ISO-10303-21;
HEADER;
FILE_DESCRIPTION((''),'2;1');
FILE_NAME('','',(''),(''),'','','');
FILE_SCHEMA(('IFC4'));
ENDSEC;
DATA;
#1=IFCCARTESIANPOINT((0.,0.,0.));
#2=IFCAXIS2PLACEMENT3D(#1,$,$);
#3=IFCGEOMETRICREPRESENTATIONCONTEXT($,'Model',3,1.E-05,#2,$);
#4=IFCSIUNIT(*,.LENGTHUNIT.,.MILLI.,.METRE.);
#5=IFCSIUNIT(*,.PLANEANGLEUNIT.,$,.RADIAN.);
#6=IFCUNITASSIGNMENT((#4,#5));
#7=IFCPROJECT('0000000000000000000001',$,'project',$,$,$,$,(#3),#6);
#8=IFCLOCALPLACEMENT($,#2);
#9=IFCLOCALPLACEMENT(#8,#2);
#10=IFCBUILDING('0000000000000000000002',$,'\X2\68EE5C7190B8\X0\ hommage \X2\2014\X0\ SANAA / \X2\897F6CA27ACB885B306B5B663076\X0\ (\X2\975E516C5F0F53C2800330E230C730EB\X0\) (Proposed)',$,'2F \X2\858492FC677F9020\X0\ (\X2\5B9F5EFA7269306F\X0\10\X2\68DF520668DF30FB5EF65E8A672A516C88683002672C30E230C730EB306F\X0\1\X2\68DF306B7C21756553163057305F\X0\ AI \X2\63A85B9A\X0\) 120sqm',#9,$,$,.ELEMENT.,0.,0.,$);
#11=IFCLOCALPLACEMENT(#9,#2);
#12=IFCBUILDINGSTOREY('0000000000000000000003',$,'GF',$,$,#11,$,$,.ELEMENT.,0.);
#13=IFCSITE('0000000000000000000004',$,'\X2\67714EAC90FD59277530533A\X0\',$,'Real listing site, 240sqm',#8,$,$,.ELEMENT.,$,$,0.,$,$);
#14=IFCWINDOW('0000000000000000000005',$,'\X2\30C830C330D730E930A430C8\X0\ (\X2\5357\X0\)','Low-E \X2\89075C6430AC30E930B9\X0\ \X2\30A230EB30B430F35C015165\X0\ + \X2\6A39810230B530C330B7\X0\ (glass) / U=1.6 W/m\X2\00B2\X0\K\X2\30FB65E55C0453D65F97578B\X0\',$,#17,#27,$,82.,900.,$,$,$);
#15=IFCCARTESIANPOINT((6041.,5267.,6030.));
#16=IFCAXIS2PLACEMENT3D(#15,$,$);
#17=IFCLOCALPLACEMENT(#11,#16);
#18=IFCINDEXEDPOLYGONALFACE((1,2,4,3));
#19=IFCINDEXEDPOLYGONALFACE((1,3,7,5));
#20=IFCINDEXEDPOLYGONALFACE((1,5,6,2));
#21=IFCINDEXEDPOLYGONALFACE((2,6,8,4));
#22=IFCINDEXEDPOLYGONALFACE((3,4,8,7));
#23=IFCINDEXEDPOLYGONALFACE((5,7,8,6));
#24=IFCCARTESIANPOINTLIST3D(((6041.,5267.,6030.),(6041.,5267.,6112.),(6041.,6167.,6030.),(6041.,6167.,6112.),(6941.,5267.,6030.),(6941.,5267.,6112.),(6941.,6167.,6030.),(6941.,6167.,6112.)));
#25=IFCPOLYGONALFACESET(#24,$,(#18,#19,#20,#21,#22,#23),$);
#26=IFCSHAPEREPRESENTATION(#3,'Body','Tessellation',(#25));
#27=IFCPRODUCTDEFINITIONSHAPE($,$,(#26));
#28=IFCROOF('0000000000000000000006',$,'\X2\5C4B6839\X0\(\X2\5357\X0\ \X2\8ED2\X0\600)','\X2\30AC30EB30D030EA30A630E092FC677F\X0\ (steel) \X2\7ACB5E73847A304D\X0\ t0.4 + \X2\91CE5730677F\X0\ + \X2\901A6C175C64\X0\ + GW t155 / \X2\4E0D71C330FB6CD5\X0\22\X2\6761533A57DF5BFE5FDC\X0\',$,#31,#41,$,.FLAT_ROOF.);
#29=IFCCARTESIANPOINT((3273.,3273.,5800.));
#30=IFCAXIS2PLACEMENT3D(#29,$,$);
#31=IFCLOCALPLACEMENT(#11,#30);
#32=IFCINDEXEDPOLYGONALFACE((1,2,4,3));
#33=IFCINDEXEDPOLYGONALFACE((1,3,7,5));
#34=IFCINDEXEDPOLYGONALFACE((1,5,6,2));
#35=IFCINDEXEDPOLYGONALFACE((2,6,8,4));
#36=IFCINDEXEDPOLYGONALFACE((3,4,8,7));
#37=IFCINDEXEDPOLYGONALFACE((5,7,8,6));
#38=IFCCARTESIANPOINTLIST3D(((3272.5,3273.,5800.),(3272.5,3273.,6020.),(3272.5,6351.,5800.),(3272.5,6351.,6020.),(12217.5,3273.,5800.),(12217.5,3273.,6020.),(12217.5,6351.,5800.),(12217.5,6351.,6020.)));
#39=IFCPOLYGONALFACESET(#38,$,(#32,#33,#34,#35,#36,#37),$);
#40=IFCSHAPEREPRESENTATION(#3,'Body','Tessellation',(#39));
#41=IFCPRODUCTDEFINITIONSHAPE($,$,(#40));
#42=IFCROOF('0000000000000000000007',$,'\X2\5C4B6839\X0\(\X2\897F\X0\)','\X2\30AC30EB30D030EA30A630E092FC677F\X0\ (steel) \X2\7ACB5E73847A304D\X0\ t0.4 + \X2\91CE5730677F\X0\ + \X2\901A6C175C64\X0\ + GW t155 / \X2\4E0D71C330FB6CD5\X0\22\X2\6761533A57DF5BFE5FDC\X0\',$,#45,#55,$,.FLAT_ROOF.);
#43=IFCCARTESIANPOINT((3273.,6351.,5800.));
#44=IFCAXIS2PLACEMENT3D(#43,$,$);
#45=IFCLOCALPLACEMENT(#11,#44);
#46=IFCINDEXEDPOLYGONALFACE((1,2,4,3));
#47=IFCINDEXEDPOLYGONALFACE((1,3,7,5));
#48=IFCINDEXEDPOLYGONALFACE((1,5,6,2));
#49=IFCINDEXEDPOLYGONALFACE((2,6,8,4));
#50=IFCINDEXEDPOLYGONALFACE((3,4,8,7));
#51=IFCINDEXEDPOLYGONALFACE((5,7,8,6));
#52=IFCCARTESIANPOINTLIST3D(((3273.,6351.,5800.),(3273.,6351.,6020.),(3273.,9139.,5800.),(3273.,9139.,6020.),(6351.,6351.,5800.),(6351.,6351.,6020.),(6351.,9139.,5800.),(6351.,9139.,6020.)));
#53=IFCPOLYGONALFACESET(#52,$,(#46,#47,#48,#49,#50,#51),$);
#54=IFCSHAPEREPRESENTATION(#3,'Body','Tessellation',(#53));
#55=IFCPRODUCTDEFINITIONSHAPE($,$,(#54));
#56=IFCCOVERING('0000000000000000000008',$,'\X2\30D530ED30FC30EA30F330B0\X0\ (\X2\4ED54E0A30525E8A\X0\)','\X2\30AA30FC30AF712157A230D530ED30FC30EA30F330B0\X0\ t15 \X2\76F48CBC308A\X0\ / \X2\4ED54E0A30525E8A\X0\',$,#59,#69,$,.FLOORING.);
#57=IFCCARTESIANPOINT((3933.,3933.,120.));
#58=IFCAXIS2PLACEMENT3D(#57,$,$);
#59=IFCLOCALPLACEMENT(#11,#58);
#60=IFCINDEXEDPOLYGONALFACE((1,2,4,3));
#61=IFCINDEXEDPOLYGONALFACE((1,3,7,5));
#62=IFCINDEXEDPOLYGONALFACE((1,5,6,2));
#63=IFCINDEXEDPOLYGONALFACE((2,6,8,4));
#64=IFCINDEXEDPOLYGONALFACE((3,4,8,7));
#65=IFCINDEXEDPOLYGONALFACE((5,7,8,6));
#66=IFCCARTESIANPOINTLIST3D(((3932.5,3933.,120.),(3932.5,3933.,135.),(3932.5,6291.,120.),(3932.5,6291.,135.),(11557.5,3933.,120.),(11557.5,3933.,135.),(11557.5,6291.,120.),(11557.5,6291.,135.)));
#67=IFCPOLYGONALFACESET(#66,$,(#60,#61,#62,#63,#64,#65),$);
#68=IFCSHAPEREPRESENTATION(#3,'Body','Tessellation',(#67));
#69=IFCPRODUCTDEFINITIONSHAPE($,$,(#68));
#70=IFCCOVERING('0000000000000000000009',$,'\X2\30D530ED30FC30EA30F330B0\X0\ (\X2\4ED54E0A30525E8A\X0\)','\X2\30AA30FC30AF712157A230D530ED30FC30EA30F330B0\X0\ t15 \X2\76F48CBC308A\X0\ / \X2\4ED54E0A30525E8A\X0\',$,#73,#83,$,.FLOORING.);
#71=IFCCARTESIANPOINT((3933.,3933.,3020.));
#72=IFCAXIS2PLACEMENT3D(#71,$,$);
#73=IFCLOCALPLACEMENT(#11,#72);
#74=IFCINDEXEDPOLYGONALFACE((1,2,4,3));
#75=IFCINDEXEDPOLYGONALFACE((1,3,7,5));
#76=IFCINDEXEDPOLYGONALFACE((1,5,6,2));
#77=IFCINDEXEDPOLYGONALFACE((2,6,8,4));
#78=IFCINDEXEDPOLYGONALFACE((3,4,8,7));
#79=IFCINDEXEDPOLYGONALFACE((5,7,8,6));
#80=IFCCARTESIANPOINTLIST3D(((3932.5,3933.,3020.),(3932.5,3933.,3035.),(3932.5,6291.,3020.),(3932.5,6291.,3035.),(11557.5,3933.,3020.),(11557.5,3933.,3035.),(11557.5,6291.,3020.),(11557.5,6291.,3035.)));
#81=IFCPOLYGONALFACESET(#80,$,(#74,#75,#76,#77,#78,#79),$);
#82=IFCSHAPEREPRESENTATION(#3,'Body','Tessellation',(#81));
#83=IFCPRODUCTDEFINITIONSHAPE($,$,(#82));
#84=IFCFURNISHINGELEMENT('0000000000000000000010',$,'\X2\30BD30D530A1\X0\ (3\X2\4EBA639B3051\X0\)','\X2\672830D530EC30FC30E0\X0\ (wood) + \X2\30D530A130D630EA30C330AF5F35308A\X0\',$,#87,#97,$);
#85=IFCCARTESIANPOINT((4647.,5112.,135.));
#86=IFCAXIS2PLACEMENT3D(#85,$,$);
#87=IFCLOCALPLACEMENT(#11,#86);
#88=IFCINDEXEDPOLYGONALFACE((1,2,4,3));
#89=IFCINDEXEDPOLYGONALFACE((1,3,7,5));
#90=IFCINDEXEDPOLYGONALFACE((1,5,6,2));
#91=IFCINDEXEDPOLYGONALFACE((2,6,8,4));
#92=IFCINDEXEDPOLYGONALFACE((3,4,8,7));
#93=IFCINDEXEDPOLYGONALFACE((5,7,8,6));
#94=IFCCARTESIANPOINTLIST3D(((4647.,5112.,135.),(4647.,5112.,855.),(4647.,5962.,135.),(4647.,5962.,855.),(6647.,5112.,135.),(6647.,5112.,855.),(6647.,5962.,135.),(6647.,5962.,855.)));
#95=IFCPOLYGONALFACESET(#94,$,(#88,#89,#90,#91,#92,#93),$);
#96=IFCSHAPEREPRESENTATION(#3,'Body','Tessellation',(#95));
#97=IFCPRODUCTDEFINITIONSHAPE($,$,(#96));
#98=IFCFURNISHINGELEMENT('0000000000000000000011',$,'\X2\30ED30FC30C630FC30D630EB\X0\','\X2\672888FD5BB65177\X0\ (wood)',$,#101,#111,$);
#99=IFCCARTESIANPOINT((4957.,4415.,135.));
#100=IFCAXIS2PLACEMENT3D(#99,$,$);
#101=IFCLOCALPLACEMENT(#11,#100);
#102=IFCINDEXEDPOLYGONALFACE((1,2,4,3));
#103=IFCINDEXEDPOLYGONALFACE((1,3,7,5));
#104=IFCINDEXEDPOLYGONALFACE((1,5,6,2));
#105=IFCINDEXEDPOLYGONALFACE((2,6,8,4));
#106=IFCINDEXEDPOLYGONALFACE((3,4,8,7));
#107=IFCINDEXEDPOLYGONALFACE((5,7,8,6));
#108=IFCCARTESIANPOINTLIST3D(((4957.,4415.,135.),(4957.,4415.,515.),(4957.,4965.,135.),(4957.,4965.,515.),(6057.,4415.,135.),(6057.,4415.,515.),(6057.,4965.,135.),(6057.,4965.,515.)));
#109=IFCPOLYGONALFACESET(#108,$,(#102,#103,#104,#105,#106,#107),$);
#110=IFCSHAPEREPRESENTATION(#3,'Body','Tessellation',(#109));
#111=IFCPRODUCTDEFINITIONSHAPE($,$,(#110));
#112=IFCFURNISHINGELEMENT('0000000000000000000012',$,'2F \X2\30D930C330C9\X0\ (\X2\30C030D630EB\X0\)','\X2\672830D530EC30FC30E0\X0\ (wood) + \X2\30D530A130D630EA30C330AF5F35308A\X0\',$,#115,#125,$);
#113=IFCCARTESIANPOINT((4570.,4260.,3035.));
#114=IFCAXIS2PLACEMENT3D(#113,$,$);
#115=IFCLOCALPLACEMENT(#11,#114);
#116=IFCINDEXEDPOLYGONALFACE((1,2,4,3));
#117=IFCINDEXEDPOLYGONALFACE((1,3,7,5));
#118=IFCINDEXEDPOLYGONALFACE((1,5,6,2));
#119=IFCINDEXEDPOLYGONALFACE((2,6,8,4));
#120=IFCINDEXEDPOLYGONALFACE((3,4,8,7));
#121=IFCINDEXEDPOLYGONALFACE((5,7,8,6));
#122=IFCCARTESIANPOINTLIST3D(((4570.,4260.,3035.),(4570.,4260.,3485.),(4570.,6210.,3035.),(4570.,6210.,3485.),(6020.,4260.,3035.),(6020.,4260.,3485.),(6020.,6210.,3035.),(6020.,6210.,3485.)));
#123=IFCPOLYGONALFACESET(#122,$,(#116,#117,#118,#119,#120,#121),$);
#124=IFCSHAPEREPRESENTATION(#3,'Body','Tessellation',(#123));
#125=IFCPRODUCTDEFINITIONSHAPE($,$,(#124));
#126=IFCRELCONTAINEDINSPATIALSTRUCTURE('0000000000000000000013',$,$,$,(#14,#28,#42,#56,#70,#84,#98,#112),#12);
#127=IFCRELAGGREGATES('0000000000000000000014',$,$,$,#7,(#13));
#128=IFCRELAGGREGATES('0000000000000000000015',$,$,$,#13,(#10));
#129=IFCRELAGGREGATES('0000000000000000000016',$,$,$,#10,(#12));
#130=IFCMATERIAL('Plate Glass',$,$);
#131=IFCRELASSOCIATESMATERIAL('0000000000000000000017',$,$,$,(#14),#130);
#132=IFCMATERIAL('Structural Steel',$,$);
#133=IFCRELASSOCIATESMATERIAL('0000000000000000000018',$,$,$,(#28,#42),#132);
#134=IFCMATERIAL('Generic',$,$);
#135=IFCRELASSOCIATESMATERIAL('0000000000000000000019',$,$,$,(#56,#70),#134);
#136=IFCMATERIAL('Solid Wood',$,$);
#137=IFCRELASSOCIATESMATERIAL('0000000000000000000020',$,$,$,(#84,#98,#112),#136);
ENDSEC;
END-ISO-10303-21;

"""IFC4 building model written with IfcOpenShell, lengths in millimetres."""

from ifc_helpers import new_model, si_unit, frame, frame_2d, origin, place, context, project, spatial, rectangle, extrude, material, element, save


model = new_model("IFC4")

# Units and contexts
model_context = context("Model", 3, precision=1e-05, world=origin())
ifc_project = project(units=[si_unit("LENGTHUNIT", "METRE", prefix="MILLI"), si_unit("PLANEANGLEUNIT", "RADIAN")], contexts=[model_context])

# Site, building, storey
site_placement = place(None, origin())
site = spatial("IfcSite", under=ifc_project, at=site_placement, Name="東京都大田区", ObjectType="Real listing site, 240sqm", CompositionType="ELEMENT", RefElevation=0.0)
building_placement = place(site_placement, origin())
building = spatial("IfcBuilding", under=site, at=building_placement, Name="森山邸 hommage — SANAA / 西沢立衛に学ぶ (非公式参考モデル) (Proposed)", ObjectType="2F 薄鋼板造 (実建物は10棟分棟・延床未公表。本モデルは1棟に簡略化した AI 推定) 120sqm", CompositionType="ELEMENT", ElevationOfRefHeight=0.0, ElevationOfTerrain=0.0)
storey_placement = place(building_placement, origin())
storey = spatial("IfcBuildingStorey", under=building, at=storey_placement, Name="GF", CompositionType="ELEMENT", Elevation=0.0)

# Shared definitions
ifc_material_1 = material(Name="Solid Wood")

# Shared definitions
ifc_material_2 = material(Name="Plate Glass")

# Window
window_1_placement = place(storey_placement, frame((6041.0, 5267.0, 6030.0)))
element("IfcWindow", 1, at=window_1_placement, inside=storey, material=ifc_material_2, Name="トップライト (南)", Description="Low-E 複層ガラス アルゴン封入 + 樹脂サッシ (glass) / U=1.6 W/m²K・日射取得型", OverallHeight=82.0, OverallWidth=900.0, context=model_context, shape_type="SweptSolid", body=[
    extrude(rectangle(XDim=900.0, YDim=900.0, at=frame_2d((450.0, 450.0))), frame((6041.0, 5267.0, 6030.0)), (0.0, 0.0, 1.0), 82.0),
])

# Roofs
ifc_material_3 = material(Name="Structural Steel")
roof_1_placement = place(storey_placement, frame((3273.0, 3273.0, 5800.0)))
element("IfcRoof", 2, at=roof_1_placement, inside=storey, material=ifc_material_3, Name="屋根(南 軒600)", Description="ガルバリウム鋼板 (steel) 立平葺き t0.4 + 野地板 + 通気層 + GW t155 / 不燃・法22条区域対応", PredefinedType="FLAT_ROOF", context=model_context, shape_type="SweptSolid", body=[
    extrude(rectangle(XDim=8945.0, YDim=3078.0, at=frame_2d((4472.0, 1539.0))), frame((3273.0, 3273.0, 5800.0)), (0.0, 0.0, 1.0), 220.0),
])
roof_2_placement = place(storey_placement, frame((3273.0, 6351.0, 5800.0)))
element("IfcRoof", 3, at=roof_2_placement, inside=storey, material=ifc_material_3, Name="屋根(西)", Description="ガルバリウム鋼板 (steel) 立平葺き t0.4 + 野地板 + 通気層 + GW t155 / 不燃・法22条区域対応", PredefinedType="FLAT_ROOF", context=model_context, shape_type="SweptSolid", body=[
    extrude(rectangle(XDim=3078.0, YDim=2788.0, at=frame_2d((1539.0, 1394.0))), frame((3273.0, 6351.0, 5800.0)), (0.0, 0.0, 1.0), 220.0),
])

# Coverings
ifc_material_4 = material(Name="Generic")
covering_1_placement = place(storey_placement, frame((3933.0, 3933.0, 120.0)))
element("IfcCovering", 4, at=covering_1_placement, inside=storey, material=ifc_material_4, Name="フローリング (仕上げ床)", Description="オーク無垢フローリング t15 直貼り / 仕上げ床", PredefinedType="FLOORING", context=model_context, shape_type="SweptSolid", body=[
    extrude(rectangle(XDim=7625.0, YDim=2358.0, at=frame_2d((3812.0, 1179.0))), frame((3933.0, 3933.0, 120.0)), (0.0, 0.0, 1.0), 15.0),
])
covering_2_placement = place(storey_placement, frame((3933.0, 3933.0, 3020.0)))
element("IfcCovering", 5, at=covering_2_placement, inside=storey, material=ifc_material_4, Name="フローリング (仕上げ床)", Description="オーク無垢フローリング t15 直貼り / 仕上げ床", PredefinedType="FLOORING", context=model_context, shape_type="SweptSolid", body=[
    extrude(rectangle(XDim=7625.0, YDim=2358.0, at=frame_2d((3812.0, 1179.0))), frame((3933.0, 3933.0, 3020.0)), (0.0, 0.0, 1.0), 15.0),
])

# Furnishing elements
furnishing_1_placement = place(storey_placement, frame((4647.0, 5112.0, 135.0)))
element("IfcFurnishingElement", 6, at=furnishing_1_placement, inside=storey, material=ifc_material_1, Name="ソファ (3人掛け)", Description="木フレーム (wood) + ファブリック張り", context=model_context, shape_type="SweptSolid", body=[
    extrude(rectangle(XDim=2000.0, YDim=850.0, at=frame_2d((1000.0, 425.0))), frame((4647.0, 5112.0, 135.0)), (0.0, 0.0, 1.0), 720.0),
])
furnishing_2_placement = place(storey_placement, frame((4957.0, 4415.0, 135.0)))
element("IfcFurnishingElement", 7, at=furnishing_2_placement, inside=storey, material=ifc_material_1, Name="ローテーブル", Description="木製家具 (wood)", context=model_context, shape_type="SweptSolid", body=[
    extrude(rectangle(XDim=1100.0, YDim=550.0, at=frame_2d((550.0, 275.0))), frame((4957.0, 4415.0, 135.0)), (0.0, 0.0, 1.0), 380.0),
])
furnishing_3_placement = place(storey_placement, frame((4570.0, 4260.0, 3035.0)))
element("IfcFurnishingElement", 8, at=furnishing_3_placement, inside=storey, material=ifc_material_1, Name="2F ベッド (ダブル)", Description="木フレーム (wood) + ファブリック張り", context=model_context, shape_type="SweptSolid", body=[
    extrude(rectangle(XDim=1450.0, YDim=1950.0, at=frame_2d((725.0, 975.0))), frame((4570.0, 4260.0, 3035.0)), (0.0, 0.0, 1.0), 450.0),
])

save(model, "model.ifc")
